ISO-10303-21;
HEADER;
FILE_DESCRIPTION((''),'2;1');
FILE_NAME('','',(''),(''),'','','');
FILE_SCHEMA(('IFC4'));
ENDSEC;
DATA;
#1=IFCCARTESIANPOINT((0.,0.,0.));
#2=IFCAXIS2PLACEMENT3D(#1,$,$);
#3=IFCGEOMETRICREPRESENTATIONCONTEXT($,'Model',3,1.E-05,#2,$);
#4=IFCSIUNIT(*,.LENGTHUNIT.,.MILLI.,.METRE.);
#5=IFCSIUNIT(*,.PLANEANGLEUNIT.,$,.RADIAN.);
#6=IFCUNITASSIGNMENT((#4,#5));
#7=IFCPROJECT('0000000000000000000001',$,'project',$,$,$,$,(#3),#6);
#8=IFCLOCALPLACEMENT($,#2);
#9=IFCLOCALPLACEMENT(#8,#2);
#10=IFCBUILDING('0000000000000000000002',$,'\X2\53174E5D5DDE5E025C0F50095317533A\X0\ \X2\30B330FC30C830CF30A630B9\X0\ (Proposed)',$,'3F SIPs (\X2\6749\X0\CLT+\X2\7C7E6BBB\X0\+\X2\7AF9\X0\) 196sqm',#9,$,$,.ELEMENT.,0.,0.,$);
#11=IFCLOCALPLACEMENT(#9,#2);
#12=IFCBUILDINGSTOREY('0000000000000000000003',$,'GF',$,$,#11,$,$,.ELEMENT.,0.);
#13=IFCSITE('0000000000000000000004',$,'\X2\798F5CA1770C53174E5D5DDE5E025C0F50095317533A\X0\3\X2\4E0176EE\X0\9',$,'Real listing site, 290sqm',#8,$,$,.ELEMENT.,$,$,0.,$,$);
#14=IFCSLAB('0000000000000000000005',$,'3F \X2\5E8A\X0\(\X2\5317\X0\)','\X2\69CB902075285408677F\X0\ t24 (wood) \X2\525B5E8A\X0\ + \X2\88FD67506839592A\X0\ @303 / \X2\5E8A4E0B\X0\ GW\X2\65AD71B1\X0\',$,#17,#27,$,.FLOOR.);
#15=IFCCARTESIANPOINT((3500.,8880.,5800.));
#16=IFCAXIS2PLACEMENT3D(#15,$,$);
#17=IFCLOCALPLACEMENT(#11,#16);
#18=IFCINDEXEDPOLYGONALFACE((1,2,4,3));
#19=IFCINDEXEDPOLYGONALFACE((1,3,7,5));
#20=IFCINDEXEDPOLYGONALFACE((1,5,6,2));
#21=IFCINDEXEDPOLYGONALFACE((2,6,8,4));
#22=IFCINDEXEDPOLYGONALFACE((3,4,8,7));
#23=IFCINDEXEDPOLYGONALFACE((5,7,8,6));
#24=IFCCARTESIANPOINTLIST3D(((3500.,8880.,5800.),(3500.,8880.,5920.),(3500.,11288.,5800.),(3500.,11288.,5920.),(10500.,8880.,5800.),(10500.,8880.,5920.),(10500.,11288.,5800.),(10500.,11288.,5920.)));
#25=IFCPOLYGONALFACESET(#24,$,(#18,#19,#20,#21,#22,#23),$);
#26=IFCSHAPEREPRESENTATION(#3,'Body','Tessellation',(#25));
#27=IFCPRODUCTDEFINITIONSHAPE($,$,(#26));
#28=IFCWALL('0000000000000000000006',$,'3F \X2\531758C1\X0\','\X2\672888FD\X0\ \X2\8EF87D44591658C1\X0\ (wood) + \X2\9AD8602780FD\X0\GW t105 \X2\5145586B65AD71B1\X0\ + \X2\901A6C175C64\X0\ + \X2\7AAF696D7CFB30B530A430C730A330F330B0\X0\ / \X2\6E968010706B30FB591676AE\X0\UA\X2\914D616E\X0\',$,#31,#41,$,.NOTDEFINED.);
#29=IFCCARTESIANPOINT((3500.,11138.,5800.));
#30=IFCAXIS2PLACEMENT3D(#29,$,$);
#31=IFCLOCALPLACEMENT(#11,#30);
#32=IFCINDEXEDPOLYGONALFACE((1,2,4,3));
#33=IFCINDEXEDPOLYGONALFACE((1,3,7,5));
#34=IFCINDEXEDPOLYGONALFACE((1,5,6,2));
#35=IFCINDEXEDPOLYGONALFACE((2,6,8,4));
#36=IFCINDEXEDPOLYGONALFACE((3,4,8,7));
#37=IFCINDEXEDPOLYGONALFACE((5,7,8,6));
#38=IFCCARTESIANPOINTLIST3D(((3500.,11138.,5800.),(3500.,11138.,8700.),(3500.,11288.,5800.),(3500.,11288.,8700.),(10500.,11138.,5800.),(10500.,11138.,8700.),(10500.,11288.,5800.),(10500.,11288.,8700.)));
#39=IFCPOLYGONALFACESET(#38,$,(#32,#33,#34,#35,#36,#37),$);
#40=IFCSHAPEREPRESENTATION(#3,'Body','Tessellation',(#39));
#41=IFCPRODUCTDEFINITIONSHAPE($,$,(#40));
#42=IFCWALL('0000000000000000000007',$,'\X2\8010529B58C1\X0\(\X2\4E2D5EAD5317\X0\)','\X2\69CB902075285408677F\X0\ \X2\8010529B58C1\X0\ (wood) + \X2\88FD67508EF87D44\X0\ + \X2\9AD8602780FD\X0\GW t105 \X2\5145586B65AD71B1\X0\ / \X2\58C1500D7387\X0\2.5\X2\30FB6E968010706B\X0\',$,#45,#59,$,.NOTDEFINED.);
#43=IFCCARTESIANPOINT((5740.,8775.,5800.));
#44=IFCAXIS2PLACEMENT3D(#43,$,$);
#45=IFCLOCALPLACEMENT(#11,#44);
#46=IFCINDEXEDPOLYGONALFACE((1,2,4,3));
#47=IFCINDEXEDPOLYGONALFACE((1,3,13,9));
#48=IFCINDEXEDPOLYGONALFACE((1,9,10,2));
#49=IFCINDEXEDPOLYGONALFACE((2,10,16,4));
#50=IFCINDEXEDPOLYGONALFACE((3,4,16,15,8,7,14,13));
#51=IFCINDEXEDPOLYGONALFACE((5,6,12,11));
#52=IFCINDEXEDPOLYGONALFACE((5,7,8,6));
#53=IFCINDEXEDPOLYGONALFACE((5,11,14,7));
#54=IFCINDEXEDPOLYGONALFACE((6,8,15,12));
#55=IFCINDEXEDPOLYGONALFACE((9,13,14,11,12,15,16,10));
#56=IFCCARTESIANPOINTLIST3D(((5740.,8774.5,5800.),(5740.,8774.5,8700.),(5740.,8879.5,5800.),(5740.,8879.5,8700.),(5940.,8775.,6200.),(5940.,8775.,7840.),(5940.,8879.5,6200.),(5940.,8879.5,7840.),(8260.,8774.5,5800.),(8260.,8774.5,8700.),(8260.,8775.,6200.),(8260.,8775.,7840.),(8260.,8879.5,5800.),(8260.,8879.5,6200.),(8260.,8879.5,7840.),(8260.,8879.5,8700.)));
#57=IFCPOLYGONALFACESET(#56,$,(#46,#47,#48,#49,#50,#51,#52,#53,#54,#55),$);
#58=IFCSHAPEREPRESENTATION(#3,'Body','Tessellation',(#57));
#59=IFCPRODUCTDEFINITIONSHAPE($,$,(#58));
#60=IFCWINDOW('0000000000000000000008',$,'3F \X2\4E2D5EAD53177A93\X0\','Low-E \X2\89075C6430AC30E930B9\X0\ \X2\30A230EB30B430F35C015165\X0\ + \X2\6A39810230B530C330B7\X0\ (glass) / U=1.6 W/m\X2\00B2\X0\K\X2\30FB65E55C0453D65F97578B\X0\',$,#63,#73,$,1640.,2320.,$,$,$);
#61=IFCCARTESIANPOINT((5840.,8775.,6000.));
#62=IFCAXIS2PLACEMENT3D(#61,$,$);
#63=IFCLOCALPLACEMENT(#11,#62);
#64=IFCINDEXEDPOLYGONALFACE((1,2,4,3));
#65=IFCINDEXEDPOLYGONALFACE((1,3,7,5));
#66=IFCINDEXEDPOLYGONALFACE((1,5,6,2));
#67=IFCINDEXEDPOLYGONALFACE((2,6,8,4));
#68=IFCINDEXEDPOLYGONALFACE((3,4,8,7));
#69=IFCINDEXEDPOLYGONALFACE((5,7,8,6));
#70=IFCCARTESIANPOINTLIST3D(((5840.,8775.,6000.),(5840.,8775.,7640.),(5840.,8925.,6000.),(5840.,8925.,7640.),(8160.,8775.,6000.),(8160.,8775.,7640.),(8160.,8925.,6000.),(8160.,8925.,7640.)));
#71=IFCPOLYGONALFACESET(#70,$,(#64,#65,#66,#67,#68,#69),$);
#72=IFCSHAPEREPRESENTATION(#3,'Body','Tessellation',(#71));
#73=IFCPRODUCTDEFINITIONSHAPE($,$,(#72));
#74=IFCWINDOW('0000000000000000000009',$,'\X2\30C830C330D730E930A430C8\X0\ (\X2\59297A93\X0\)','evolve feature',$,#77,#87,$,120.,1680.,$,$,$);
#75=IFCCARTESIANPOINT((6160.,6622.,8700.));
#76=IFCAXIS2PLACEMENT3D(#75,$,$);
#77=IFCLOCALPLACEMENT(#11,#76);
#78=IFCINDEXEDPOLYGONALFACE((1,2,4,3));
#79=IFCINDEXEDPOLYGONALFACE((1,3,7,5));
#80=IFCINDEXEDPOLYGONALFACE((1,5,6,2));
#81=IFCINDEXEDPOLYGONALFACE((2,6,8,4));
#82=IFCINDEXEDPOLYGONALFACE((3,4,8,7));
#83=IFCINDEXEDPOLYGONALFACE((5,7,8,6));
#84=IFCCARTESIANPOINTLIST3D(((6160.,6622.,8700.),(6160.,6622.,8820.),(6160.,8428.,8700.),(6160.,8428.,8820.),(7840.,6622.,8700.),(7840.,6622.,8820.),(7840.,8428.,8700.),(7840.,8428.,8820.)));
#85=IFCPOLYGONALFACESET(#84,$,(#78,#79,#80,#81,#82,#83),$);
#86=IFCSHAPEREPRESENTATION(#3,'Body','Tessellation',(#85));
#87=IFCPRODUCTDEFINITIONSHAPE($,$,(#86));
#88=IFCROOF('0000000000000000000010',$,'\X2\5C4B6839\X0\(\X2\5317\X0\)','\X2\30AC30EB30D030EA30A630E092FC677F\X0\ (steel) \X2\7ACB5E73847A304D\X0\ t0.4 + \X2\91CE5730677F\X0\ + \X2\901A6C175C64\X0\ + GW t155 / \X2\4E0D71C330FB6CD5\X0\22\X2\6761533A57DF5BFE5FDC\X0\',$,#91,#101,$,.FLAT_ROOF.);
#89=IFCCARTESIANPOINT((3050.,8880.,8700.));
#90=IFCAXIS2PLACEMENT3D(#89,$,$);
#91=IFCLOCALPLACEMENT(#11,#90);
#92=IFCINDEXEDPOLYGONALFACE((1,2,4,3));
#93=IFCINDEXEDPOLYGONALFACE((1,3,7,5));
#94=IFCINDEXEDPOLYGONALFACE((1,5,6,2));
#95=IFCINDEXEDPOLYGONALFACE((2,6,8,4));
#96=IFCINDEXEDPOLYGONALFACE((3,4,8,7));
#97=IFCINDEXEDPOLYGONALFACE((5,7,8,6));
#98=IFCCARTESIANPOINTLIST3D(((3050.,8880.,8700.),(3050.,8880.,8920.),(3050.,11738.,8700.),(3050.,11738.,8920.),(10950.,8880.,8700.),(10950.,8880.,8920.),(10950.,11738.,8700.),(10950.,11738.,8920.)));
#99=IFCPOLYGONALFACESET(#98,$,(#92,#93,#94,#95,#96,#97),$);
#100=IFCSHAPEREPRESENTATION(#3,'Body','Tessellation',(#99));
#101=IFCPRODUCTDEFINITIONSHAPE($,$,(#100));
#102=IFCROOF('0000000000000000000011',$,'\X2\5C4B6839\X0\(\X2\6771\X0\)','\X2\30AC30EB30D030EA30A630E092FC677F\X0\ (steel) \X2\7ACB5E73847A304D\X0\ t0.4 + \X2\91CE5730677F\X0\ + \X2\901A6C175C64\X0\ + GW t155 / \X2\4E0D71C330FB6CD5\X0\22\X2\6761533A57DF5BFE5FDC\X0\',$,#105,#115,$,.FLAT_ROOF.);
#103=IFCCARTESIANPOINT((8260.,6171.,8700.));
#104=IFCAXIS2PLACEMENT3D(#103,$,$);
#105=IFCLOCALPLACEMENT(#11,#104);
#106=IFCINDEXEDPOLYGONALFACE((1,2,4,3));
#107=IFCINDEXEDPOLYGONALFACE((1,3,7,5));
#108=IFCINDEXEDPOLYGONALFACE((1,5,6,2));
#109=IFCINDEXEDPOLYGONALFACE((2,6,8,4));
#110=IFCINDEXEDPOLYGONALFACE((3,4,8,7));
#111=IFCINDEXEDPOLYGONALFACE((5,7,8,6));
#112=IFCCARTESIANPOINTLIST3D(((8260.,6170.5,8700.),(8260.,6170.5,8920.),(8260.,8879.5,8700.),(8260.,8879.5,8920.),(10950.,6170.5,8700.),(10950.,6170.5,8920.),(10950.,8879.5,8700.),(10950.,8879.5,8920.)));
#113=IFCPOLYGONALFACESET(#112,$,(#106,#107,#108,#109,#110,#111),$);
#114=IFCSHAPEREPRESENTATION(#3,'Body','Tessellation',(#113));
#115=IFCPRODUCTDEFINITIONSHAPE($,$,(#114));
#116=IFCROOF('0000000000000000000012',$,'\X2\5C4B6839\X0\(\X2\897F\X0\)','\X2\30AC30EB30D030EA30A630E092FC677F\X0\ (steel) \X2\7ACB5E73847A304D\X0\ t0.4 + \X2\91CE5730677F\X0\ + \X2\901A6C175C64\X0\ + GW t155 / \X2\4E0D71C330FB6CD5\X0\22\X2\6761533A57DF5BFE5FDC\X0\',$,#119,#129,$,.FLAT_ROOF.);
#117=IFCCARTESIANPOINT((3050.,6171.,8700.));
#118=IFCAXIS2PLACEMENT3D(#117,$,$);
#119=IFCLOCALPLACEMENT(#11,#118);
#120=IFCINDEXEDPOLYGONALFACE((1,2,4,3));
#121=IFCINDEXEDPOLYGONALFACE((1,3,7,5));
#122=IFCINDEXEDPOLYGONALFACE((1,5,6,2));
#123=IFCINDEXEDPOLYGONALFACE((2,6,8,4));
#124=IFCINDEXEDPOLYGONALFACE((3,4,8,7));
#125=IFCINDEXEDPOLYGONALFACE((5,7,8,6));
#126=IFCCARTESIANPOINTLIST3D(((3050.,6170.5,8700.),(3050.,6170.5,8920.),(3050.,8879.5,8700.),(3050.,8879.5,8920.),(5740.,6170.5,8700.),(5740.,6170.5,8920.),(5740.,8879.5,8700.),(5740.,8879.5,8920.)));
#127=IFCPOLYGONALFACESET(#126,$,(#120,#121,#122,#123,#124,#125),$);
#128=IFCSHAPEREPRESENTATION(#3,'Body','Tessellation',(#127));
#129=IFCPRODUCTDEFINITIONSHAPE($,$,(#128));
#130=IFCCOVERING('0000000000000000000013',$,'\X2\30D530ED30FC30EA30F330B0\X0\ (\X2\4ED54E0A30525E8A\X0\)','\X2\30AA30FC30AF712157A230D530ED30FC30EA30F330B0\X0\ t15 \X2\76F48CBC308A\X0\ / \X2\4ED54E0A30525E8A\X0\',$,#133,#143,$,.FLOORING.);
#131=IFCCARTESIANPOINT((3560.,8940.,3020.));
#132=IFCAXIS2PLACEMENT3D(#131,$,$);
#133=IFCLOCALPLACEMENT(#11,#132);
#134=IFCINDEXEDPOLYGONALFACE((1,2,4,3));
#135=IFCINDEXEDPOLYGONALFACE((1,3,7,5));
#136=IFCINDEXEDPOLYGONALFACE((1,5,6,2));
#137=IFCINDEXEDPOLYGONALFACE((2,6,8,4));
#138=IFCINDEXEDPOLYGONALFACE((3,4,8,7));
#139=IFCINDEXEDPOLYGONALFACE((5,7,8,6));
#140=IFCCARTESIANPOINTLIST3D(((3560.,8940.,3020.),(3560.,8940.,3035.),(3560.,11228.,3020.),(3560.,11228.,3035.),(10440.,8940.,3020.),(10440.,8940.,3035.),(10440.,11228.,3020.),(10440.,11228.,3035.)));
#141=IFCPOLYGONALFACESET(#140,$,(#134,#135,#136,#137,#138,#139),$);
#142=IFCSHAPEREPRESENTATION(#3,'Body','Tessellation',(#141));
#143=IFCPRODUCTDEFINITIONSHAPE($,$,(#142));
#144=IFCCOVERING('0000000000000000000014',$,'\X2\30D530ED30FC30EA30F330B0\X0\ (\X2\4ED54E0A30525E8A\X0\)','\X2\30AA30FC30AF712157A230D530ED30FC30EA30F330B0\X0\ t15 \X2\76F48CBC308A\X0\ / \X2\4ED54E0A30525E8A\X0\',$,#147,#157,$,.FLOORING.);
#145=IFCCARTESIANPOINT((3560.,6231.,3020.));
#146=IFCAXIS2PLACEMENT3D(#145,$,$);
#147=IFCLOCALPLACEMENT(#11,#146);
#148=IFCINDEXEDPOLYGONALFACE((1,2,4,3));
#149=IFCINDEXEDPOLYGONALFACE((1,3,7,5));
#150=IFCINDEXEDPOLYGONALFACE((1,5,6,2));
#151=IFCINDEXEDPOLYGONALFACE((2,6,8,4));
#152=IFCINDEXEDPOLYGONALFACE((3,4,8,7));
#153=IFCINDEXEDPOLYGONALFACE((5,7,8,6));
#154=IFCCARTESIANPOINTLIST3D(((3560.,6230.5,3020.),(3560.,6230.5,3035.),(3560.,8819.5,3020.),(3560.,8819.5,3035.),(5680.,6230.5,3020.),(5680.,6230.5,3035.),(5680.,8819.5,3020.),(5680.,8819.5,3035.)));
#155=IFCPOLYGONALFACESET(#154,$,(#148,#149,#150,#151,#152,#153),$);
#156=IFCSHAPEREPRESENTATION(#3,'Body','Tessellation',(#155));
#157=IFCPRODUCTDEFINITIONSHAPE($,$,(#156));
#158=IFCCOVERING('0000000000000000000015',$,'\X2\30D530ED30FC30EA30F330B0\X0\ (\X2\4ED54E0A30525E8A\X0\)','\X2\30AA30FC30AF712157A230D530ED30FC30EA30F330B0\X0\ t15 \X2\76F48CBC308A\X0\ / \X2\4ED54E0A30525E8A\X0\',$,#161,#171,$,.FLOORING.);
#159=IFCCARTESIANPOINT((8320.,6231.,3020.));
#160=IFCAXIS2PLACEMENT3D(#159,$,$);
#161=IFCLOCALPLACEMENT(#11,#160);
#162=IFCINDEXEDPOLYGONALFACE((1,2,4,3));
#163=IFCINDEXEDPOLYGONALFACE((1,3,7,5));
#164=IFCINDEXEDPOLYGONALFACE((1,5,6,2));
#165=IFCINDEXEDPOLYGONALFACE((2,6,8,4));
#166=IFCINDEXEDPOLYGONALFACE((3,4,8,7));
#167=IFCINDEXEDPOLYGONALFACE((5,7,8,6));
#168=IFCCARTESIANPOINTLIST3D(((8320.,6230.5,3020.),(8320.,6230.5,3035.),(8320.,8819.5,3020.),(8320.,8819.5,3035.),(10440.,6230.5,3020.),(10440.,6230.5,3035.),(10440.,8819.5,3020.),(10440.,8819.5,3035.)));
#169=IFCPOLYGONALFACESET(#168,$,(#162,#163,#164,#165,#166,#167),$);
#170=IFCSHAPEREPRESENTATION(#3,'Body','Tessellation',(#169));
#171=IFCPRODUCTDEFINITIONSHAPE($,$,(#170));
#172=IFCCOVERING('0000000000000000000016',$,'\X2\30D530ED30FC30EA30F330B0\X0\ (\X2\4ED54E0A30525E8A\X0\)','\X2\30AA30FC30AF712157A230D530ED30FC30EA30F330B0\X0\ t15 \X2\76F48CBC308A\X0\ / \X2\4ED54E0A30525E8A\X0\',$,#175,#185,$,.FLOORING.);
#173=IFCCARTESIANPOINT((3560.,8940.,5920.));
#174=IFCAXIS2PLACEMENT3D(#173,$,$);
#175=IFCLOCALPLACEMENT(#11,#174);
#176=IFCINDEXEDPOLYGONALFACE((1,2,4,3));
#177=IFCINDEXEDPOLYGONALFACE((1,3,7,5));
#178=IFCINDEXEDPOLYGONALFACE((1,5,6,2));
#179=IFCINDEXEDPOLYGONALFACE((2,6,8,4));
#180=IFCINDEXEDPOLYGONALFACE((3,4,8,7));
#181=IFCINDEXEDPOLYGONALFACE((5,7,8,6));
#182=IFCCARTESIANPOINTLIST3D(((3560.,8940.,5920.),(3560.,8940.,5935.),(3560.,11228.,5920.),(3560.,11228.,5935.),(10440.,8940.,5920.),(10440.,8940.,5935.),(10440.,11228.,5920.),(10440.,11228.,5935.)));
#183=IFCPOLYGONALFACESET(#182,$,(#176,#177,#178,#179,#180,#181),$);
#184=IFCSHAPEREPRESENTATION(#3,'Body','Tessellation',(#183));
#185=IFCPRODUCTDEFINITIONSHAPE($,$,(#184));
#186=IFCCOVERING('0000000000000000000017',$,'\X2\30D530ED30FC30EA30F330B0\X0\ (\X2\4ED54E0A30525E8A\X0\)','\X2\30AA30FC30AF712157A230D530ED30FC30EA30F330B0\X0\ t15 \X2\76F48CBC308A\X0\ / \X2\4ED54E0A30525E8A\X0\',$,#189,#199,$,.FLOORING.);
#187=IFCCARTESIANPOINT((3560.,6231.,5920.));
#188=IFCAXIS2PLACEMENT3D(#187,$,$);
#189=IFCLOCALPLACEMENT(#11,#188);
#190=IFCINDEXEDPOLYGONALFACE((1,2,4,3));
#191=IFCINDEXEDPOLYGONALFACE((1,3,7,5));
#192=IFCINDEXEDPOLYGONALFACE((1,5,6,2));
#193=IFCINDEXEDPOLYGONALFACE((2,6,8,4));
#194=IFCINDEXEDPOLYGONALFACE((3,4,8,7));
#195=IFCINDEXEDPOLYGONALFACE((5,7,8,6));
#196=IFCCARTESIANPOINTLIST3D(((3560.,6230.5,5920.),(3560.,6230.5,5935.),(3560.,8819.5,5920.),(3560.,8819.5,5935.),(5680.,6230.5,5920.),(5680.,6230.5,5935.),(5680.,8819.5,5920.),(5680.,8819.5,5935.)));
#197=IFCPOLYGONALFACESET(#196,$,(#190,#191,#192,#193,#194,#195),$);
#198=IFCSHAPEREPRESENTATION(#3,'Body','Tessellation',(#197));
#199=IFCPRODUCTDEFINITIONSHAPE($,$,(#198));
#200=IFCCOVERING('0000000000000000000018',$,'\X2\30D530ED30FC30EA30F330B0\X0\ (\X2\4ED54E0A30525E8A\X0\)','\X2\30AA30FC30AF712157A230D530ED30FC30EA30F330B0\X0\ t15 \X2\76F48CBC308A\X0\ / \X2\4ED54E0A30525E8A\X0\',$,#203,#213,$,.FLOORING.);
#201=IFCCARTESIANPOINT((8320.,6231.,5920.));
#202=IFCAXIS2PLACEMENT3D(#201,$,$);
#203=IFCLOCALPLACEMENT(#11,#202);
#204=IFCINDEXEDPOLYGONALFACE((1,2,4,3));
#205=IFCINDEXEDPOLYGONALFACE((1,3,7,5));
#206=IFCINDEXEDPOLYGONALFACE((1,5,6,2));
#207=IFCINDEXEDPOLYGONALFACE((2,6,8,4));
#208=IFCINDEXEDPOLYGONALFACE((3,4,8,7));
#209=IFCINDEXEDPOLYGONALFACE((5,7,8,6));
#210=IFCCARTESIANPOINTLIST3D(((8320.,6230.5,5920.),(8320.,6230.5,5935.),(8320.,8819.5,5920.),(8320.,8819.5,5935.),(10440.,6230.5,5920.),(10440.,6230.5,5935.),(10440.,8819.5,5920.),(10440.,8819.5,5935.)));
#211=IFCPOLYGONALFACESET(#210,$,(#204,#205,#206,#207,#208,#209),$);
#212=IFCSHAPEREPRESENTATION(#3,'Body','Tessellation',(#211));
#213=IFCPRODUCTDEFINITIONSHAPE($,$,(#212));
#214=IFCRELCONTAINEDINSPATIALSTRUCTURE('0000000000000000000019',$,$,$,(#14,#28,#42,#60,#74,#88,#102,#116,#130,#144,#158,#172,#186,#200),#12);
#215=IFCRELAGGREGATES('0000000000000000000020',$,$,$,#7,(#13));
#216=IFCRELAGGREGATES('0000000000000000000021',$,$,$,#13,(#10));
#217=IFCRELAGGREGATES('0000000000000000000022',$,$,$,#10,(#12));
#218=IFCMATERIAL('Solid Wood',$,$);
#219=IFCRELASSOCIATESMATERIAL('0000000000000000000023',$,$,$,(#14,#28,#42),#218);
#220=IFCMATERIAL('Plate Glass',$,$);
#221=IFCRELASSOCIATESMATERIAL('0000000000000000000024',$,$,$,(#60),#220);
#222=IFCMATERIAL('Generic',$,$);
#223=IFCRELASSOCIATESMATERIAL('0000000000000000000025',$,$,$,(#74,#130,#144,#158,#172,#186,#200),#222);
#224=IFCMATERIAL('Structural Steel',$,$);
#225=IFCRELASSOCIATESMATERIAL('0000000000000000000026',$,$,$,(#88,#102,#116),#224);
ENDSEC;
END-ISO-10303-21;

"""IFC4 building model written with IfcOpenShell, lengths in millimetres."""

from ifc_helpers import new_model, si_unit, frame, frame_2d, origin, place, context, project, spatial, rectangle, extrude, material, element, fill, save


model = new_model("IFC4")

# Units and contexts
model_context = context("Model", 3, precision=1e-05, world=origin())
ifc_project = project(units=[si_unit("LENGTHUNIT", "METRE", prefix="MILLI"), si_unit("PLANEANGLEUNIT", "RADIAN")], contexts=[model_context])

# Site, building, storey
site_placement = place(None, origin())
site = spatial("IfcSite", under=ifc_project, at=site_placement, Name="福岡県北九州市小倉北区3丁目9", ObjectType="Real listing site, 290sqm", CompositionType="ELEMENT", RefElevation=0.0)
building_placement = place(site_placement, origin())
building = spatial("IfcBuilding", under=site, at=building_placement, Name="北九州市小倉北区 コートハウス (Proposed)", ObjectType="3F SIPs (杉CLT+籾殻+竹) 196sqm", CompositionType="ELEMENT", ElevationOfRefHeight=0.0, ElevationOfTerrain=0.0)
storey_placement = place(building_placement, origin())
storey = spatial("IfcBuildingStorey", under=building, at=storey_placement, Name="GF", CompositionType="ELEMENT", Elevation=0.0)

# Slab
ifc_material_1 = material(Name="Solid Wood")
slab_placement = place(storey_placement, frame((3500.0, 8880.0, 5800.0)))
element("IfcSlab", 1, at=slab_placement, inside=storey, material=ifc_material_1, Name="3F 床(北)", Description="構造用合板 t24 (wood) 剛床 + 製材根太 @303 / 床下 GW断熱", PredefinedType="FLOOR", context=model_context, shape_type="SweptSolid", body=[
    extrude(rectangle(XDim=7000.0, YDim=2408.0, at=frame_2d((3500.0, 1204.0))), frame((3500.0, 8880.0, 5800.0)), (0.0, 0.0, 1.0), 120.0),
])

# Wall
wall_1_placement = place(storey_placement, frame((3500.0, 11138.0, 5800.0)))
element("IfcWall", 2, at=wall_1_placement, inside=storey, material=ifc_material_1, Name="3F 北壁", Description="木製 軸組外壁 (wood) + 高性能GW t105 充填断熱 + 通気層 + 窯業系サイディング / 準耐火・外皮UA配慮", PredefinedType="NOTDEFINED", context=model_context, shape_type="SweptSolid", body=[
    extrude(rectangle(XDim=7000.0, YDim=150.0, at=frame_2d((3500.0, 75.0))), frame((3500.0, 11138.0, 5800.0)), (0.0, 0.0, 1.0), 2900.0),
])

# Wall, opening, window
wall_2_placement = place(storey_placement, frame((5740.0, 8775.0, 5800.0)))
wall_2 = element("IfcWall", 3, at=wall_2_placement, inside=storey, material=ifc_material_1, Name="耐力壁(中庭北)", Description="構造用合板 耐力壁 (wood) + 製材軸組 + 高性能GW t105 充填断熱 / 壁倍率2.5・準耐火", PredefinedType="NOTDEFINED", context=model_context, shape_type="SweptSolid", body=[
    extrude(rectangle(XDim=2520.0, YDim=105.0, at=frame_2d((1260.0, 52.0))), frame((5740.0, 8775.0, 5800.0)), (0.0, 0.0, 1.0), 2900.0),
])
opening_placement = place(storey_placement, frame((5840.0, 8775.0, 6000.0)))
opening = element("IfcOpeningElement", 4, at=opening_placement, cuts=wall_2, PredefinedType="NOTDEFINED", context=model_context, shape_type="SweptSolid", body=[
    extrude(rectangle(XDim=2320.0, YDim=150.0, at=frame_2d((1160.0, 75.0))), frame((5840.0, 8775.0, 6000.0)), (0.0, 0.0, 1.0), 1640.0),
])
ifc_material_2 = material(Name="Plate Glass")
window_1_placement = place(storey_placement, frame((5840.0, 8775.0, 6000.0)))
window_1 = element("IfcWindow", 5, at=window_1_placement, inside=storey, material=ifc_material_2, Name="3F 中庭北窓", Description="Low-E 複層ガラス アルゴン封入 + 樹脂サッシ (glass) / U=1.6 W/m²K・日射取得型", OverallHeight=1640.0, OverallWidth=2320.0, context=model_context, shape_type="SweptSolid", body=[
    extrude(rectangle(XDim=2320.0, YDim=150.0, at=frame_2d((1160.0, 75.0))), frame((5840.0, 8775.0, 6000.0)), (0.0, 0.0, 1.0), 1640.0),
])
fill(opening, window_1)

# Window
ifc_material_3 = material(Name="Generic")
window_2_placement = place(storey_placement, frame((6160.0, 6622.0, 8700.0)))
element("IfcWindow", 6, at=window_2_placement, inside=storey, material=ifc_material_3, Name="トップライト (天窓)", Description="evolve feature", OverallHeight=120.0, OverallWidth=1680.0, context=model_context, shape_type="SweptSolid", body=[
    extrude(rectangle(XDim=1680.0, YDim=1806.0, at=frame_2d((840.0, 903.0))), frame((6160.0, 6622.0, 8700.0)), (0.0, 0.0, 1.0), 120.0),
])

# Roofs
ifc_material_4 = material(Name="Structural Steel")
roof_1_placement = place(storey_placement, frame((3050.0, 8880.0, 8700.0)))
element("IfcRoof", 7, at=roof_1_placement, inside=storey, material=ifc_material_4, Name="屋根(北)", Description="ガルバリウム鋼板 (steel) 立平葺き t0.4 + 野地板 + 通気層 + GW t155 / 不燃・法22条区域対応", PredefinedType="FLAT_ROOF", context=model_context, shape_type="SweptSolid", body=[
    extrude(rectangle(XDim=7900.0, YDim=2858.0, at=frame_2d((3950.0, 1429.0))), frame((3050.0, 8880.0, 8700.0)), (0.0, 0.0, 1.0), 220.0),
])
roof_2_placement = place(storey_placement, frame((8260.0, 6171.0, 8700.0)))
element("IfcRoof", 8, at=roof_2_placement, inside=storey, material=ifc_material_4, Name="屋根(東)", Description="ガルバリウム鋼板 (steel) 立平葺き t0.4 + 野地板 + 通気層 + GW t155 / 不燃・法22条区域対応", PredefinedType="FLAT_ROOF", context=model_context, shape_type="SweptSolid", body=[
    extrude(rectangle(XDim=2690.0, YDim=2709.0, at=frame_2d((1345.0, 1354.0))), frame((8260.0, 6171.0, 8700.0)), (0.0, 0.0, 1.0), 220.0),
])
roof_3_placement = place(storey_placement, frame((3050.0, 6171.0, 8700.0)))
element("IfcRoof", 9, at=roof_3_placement, inside=storey, material=ifc_material_4, Name="屋根(西)", Description="ガルバリウム鋼板 (steel) 立平葺き t0.4 + 野地板 + 通気層 + GW t155 / 不燃・法22条区域対応", PredefinedType="FLAT_ROOF", context=model_context, shape_type="SweptSolid", body=[
    extrude(rectangle(XDim=2690.0, YDim=2709.0, at=frame_2d((1345.0, 1354.0))), frame((3050.0, 6171.0, 8700.0)), (0.0, 0.0, 1.0), 220.0),
])

# Coverings
covering_1_placement = place(storey_placement, frame((3560.0, 8940.0, 3020.0)))
element("IfcCovering", 10, at=covering_1_placement, inside=storey, material=ifc_material_3, Name="フローリング (仕上げ床)", Description="オーク無垢フローリング t15 直貼り / 仕上げ床", PredefinedType="FLOORING", context=model_context, shape_type="SweptSolid", body=[
    extrude(rectangle(XDim=6880.0, YDim=2288.0, at=frame_2d((3440.0, 1144.0))), frame((3560.0, 8940.0, 3020.0)), (0.0, 0.0, 1.0), 15.0),
])
covering_2_placement = place(storey_placement, frame((3560.0, 6231.0, 3020.0)))
element("IfcCovering", 11, at=covering_2_placement, inside=storey, material=ifc_material_3, Name="フローリング (仕上げ床)", Description="オーク無垢フローリング t15 直貼り / 仕上げ床", PredefinedType="FLOORING", context=model_context, shape_type="SweptSolid", body=[
    extrude(rectangle(XDim=2120.0, YDim=2589.0, at=frame_2d((1060.0, 1294.0))), frame((3560.0, 6231.0, 3020.0)), (0.0, 0.0, 1.0), 15.0),
])
covering_3_placement = place(storey_placement, frame((8320.0, 6231.0, 3020.0)))
element("IfcCovering", 12, at=covering_3_placement, inside=storey, material=ifc_material_3, Name="フローリング (仕上げ床)", Description="オーク無垢フローリング t15 直貼り / 仕上げ床", PredefinedType="FLOORING", context=model_context, shape_type="SweptSolid", body=[
    extrude(rectangle(XDim=2120.0, YDim=2589.0, at=frame_2d((1060.0, 1294.0))), frame((8320.0, 6231.0, 3020.0)), (0.0, 0.0, 1.0), 15.0),
])
covering_4_placement = place(storey_placement, frame((3560.0, 8940.0, 5920.0)))
element("IfcCovering", 13, at=covering_4_placement, inside=storey, material=ifc_material_3, Name="フローリング (仕上げ床)", Description="オーク無垢フローリング t15 直貼り / 仕上げ床", PredefinedType="FLOORING", context=model_context, shape_type="SweptSolid", body=[
    extrude(rectangle(XDim=6880.0, YDim=2288.0, at=frame_2d((3440.0, 1144.0))), frame((3560.0, 8940.0, 5920.0)), (0.0, 0.0, 1.0), 15.0),
])
covering_5_placement = place(storey_placement, frame((3560.0, 6231.0, 5920.0)))
element("IfcCovering", 14, at=covering_5_placement, inside=storey, material=ifc_material_3, Name="フローリング (仕上げ床)", Description="オーク無垢フローリング t15 直貼り / 仕上げ床", PredefinedType="FLOORING", context=model_context, shape_type="SweptSolid", body=[
    extrude(rectangle(XDim=2120.0, YDim=2589.0, at=frame_2d((1060.0, 1294.0))), frame((3560.0, 6231.0, 5920.0)), (0.0, 0.0, 1.0), 15.0),
])
covering_6_placement = place(storey_placement, frame((8320.0, 6231.0, 5920.0)))
element("IfcCovering", 15, at=covering_6_placement, inside=storey, material=ifc_material_3, Name="フローリング (仕上げ床)", Description="オーク無垢フローリング t15 直貼り / 仕上げ床", PredefinedType="FLOORING", context=model_context, shape_type="SweptSolid", body=[
    extrude(rectangle(XDim=2120.0, YDim=2589.0, at=frame_2d((1060.0, 1294.0))), frame((8320.0, 6231.0, 5920.0)), (0.0, 0.0, 1.0), 15.0),
])

save(model, "model.ifc")
